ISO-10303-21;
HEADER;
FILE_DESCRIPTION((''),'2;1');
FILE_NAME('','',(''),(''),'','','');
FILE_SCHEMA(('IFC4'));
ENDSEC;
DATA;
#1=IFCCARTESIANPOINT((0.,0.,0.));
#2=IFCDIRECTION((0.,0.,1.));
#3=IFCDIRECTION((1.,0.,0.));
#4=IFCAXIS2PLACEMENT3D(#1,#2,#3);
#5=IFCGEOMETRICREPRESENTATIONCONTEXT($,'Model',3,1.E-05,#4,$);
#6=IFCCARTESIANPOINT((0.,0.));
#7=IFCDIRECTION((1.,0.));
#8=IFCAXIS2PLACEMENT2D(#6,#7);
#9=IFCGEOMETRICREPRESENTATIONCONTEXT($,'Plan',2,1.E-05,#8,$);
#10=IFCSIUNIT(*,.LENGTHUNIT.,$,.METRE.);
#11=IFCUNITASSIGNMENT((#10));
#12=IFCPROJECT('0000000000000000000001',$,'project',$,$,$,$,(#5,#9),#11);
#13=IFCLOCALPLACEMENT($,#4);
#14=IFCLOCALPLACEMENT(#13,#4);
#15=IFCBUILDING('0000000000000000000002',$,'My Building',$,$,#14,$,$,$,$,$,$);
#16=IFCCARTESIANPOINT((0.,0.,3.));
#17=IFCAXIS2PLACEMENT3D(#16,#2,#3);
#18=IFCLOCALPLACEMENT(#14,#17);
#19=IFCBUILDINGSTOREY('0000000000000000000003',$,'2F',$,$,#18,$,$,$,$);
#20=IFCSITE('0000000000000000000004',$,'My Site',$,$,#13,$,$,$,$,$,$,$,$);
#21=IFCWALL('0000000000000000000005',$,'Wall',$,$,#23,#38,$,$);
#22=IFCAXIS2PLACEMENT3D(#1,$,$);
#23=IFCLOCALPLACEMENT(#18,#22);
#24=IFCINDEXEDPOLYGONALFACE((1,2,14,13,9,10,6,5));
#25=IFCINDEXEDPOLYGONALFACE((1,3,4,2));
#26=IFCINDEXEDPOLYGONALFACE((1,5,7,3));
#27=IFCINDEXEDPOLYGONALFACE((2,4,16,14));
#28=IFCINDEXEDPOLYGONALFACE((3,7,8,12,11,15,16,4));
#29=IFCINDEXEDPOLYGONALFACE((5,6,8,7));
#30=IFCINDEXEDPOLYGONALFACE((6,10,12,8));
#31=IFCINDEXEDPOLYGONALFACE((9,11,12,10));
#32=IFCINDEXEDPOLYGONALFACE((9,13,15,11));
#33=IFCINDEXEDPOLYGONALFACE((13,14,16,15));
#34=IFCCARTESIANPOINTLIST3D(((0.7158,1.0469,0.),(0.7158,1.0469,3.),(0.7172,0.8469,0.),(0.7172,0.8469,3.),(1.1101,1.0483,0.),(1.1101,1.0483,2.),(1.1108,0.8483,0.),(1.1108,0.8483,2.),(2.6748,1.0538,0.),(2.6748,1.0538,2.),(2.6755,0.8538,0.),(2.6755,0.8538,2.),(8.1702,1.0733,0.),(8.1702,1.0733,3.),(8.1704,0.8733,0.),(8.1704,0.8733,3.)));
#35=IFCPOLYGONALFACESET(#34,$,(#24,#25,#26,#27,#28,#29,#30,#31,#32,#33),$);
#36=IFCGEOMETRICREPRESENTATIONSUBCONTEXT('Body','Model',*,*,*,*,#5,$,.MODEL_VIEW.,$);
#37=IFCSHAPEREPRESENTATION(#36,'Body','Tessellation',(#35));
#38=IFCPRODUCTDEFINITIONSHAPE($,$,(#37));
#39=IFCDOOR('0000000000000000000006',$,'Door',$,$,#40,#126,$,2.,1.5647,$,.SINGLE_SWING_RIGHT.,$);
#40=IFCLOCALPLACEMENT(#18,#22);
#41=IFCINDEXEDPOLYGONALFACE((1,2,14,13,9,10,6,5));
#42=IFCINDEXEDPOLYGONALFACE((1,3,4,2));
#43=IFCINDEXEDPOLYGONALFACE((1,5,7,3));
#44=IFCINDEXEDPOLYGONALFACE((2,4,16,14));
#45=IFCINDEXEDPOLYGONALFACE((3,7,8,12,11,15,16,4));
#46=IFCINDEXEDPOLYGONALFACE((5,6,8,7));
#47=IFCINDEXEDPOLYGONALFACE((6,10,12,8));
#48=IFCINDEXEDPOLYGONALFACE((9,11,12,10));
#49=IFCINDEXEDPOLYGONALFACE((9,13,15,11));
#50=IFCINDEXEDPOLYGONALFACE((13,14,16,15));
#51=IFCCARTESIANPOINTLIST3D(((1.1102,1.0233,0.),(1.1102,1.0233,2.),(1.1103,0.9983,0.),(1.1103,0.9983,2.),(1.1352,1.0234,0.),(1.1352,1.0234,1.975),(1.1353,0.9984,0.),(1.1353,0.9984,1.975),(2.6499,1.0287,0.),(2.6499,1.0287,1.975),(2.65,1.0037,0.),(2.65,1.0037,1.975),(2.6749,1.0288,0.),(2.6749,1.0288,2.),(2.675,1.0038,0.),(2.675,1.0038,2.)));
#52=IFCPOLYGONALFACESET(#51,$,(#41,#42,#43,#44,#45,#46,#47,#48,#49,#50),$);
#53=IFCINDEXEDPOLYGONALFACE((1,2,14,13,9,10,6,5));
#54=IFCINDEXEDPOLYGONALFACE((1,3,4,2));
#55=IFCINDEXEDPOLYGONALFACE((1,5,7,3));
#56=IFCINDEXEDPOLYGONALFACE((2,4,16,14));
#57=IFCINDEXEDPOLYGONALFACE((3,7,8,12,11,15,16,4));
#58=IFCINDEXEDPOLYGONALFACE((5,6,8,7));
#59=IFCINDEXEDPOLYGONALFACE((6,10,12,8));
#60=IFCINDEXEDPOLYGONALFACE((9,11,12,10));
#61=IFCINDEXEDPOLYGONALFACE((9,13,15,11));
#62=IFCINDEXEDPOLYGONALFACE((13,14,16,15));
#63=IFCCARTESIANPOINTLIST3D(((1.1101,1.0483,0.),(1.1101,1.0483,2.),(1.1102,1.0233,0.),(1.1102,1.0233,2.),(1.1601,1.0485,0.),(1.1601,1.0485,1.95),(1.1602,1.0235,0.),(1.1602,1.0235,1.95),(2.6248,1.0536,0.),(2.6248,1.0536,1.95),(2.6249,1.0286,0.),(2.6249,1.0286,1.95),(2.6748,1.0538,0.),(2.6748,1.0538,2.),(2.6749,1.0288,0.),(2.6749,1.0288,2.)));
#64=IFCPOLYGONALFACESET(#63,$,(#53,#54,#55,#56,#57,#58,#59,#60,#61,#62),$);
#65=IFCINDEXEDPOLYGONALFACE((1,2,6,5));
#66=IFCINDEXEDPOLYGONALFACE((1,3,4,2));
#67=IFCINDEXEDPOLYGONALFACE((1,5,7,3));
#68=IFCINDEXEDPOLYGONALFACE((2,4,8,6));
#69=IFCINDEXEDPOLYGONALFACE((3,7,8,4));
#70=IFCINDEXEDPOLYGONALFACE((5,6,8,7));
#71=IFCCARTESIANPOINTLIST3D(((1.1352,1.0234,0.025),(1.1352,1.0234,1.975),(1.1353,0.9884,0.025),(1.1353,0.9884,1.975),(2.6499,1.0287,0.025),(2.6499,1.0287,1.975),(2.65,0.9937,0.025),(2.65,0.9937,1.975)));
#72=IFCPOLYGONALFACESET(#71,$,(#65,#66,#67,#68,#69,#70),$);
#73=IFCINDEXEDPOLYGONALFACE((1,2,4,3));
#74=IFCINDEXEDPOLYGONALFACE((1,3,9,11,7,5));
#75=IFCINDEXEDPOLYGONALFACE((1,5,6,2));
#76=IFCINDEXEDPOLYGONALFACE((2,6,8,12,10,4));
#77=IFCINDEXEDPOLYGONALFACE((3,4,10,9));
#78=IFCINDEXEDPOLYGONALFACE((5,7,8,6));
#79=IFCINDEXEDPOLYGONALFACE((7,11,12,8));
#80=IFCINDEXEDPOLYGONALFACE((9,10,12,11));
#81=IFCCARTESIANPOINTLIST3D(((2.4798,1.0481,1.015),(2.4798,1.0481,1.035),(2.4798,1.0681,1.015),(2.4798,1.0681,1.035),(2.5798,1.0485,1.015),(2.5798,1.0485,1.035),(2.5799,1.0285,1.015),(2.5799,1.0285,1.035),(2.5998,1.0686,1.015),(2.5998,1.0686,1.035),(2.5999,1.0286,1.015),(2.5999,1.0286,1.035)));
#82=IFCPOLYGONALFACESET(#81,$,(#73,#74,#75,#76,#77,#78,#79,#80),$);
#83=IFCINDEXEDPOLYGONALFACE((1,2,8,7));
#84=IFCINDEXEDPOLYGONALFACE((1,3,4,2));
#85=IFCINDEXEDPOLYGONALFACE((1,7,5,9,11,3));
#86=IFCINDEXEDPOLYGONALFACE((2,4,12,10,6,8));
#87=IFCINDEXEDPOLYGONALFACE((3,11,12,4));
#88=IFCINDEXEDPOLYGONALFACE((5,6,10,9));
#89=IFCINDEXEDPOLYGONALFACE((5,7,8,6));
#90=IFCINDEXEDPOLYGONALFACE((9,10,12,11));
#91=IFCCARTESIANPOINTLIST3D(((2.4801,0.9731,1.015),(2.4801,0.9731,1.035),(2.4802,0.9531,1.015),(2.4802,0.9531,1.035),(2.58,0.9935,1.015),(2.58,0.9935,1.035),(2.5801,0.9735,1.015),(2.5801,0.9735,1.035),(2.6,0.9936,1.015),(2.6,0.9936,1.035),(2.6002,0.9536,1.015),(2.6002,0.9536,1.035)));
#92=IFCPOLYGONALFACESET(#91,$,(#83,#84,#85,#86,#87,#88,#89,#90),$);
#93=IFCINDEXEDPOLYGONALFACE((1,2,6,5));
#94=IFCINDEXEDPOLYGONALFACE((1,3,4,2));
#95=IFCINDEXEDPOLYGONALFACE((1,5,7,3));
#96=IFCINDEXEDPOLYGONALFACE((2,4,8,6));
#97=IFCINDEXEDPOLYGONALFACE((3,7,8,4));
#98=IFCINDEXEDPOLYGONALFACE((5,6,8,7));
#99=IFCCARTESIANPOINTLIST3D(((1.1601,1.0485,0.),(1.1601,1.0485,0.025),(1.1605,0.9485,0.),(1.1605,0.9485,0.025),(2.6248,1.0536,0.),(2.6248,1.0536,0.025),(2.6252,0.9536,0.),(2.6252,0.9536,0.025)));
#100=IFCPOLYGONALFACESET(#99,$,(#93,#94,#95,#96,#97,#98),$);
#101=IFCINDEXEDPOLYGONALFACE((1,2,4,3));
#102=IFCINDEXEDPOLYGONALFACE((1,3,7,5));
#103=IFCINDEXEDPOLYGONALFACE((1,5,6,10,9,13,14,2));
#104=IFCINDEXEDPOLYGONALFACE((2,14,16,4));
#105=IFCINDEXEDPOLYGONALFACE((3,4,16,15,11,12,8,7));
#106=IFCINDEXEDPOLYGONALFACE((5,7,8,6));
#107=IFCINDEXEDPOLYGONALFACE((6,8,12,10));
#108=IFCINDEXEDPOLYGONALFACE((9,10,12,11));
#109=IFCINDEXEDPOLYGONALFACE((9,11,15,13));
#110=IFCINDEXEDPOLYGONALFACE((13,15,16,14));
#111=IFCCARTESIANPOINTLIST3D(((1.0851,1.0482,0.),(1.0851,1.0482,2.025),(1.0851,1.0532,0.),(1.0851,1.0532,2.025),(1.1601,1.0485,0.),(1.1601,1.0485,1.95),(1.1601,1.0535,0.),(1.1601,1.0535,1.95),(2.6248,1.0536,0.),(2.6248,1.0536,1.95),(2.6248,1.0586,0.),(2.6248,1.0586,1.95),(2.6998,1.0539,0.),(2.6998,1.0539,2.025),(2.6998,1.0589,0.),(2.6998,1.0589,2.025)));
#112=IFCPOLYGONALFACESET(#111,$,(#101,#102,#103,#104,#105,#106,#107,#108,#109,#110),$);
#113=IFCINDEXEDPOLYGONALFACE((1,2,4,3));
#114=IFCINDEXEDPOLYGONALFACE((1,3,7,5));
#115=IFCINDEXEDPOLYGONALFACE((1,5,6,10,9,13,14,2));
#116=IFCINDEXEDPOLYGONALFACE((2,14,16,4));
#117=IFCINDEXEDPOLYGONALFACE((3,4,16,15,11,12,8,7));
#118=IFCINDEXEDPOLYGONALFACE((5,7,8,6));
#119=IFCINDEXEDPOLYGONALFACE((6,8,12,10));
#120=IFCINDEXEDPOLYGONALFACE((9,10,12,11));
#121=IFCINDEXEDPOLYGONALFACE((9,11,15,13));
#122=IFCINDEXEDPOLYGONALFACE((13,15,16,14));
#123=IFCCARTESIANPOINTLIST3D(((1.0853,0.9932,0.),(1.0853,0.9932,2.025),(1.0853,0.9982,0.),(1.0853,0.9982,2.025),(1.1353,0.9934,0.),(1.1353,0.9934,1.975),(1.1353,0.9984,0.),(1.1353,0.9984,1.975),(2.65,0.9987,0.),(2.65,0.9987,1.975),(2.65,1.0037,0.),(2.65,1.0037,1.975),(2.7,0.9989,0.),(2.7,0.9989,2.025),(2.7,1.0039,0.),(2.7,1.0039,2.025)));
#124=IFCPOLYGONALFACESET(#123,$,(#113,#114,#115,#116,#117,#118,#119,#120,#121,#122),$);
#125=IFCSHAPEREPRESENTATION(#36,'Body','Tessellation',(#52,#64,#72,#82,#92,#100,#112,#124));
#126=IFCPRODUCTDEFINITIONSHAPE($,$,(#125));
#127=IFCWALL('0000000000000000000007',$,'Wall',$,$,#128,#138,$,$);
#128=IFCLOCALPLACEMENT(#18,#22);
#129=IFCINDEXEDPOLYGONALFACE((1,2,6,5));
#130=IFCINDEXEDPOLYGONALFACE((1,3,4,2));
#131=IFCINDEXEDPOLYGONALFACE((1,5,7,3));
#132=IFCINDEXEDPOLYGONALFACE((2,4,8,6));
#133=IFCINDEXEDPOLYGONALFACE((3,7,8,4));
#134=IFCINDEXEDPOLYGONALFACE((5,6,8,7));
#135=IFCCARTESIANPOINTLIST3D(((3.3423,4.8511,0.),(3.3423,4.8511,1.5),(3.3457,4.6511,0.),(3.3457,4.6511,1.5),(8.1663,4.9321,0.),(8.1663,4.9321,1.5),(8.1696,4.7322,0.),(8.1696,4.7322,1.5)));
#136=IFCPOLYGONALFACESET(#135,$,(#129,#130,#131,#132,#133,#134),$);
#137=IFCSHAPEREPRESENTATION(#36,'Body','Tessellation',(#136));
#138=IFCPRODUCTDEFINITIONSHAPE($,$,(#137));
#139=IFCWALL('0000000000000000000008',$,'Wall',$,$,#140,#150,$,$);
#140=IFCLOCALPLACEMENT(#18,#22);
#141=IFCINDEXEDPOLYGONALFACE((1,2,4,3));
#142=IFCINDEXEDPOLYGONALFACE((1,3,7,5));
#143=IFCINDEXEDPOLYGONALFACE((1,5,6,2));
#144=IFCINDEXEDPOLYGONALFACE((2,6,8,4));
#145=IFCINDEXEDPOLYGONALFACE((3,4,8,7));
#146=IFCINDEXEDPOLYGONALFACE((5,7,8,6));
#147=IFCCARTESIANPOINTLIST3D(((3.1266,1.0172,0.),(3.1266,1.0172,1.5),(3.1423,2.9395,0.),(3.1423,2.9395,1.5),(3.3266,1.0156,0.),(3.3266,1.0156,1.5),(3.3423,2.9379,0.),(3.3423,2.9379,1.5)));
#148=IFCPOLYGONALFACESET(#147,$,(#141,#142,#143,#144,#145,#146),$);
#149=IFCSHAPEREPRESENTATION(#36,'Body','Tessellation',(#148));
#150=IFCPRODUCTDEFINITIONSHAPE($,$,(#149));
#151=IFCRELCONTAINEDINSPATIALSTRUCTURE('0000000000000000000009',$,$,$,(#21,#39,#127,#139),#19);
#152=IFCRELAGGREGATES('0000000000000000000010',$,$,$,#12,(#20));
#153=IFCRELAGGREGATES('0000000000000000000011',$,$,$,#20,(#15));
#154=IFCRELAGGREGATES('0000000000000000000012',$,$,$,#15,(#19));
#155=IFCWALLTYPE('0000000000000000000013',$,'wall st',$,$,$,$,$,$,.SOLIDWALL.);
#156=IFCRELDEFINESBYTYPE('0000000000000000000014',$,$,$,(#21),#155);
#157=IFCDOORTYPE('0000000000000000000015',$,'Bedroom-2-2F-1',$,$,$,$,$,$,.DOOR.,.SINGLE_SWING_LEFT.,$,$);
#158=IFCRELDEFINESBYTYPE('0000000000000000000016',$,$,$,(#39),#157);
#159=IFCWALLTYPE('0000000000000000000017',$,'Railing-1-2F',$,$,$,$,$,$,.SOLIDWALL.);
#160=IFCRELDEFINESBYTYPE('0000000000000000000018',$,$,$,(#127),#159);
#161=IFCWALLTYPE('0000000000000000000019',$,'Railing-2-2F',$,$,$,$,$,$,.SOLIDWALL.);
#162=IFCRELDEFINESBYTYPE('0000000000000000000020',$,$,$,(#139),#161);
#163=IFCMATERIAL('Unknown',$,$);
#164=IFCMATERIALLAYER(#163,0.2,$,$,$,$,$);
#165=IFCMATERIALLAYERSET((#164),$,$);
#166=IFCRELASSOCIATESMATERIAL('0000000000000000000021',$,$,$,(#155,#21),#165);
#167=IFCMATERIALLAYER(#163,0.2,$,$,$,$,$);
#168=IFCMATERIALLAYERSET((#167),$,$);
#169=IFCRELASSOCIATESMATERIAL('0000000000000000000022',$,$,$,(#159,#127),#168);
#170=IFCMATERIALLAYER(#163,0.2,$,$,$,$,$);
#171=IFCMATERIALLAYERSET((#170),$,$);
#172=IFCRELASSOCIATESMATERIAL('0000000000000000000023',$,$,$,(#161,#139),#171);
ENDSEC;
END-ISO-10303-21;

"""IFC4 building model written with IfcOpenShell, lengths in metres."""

from ifc_helpers import new_model, entity, si_unit, frame, origin_with_axes, origin_2d_with_axis, place, context, subcontext, project, spatial, line, indexed_curve, outline, extrude, shape, source, transform, mapped, material, layer, layer_set, layer_usage, type_object, type_shapes, element, fill, save


model = new_model("IFC4")

# Units and contexts
model_context = context("Model", 3, precision=1e-05, world=origin_with_axes())
plan_context = context("Plan", 2, precision=1e-05, world=origin_2d_with_axis())
body_context_1 = subcontext(model_context, "Body", "Model", "MODEL_VIEW")
body_context_2 = subcontext(plan_context, "Body", "Plan", "PLAN_VIEW")
ifc_project = project(units=[si_unit("LENGTHUNIT", "METRE")], contexts=[model_context, plan_context])

# Site, building, storey
site_placement = place(None, origin_with_axes())
site = spatial("IfcSite", under=ifc_project, at=site_placement, Name="My Site")
building_placement = place(site_placement, origin_with_axes())
building = spatial("IfcBuilding", under=site, at=building_placement, Name="My Building")
storey_placement = place(building_placement, frame((0.0, 0.0, 3.0), z_axis=(0.0, 0.0, 1.0), x_axis=(1.0, 0.0, 0.0)))
storey = spatial("IfcBuildingStorey", under=building, at=storey_placement, Name="2F")

# Shared definitions
ifc_material = material(Name="Unknown")

# Shared definitions
ifc_layer_1 = layer(ifc_material, 0.2)
ifc_layer_set_1 = layer_set([ifc_layer_1])
wall_type_1 = type_object("IfcWallType", Name="wall st", PredefinedType="SOLIDWALL", material=ifc_layer_set_1)

# Wall, opening, door
ifc_layer_usage_1 = layer_usage(ifc_layer_set_1, "AXIS2", "POSITIVE", 0.0)
wall_1_placement = place(storey_placement, frame((0.5172, 0.8462, 0.0), z_axis=(0.0, 0.0, 1.0), x_axis=(0.999994, 0.003537, 0.0)))
wall_1 = element("IfcWall", 1, at=wall_1_placement, inside=storey, type_object=wall_type_1, material=ifc_layer_usage_1, Name="Wall", context=body_context_1, shape_type="SweptSolid", body=[
    extrude(outline(indexed_curve([(0.2, 0.0), (0.1993, 0.2), (7.6537, 0.2), (7.6532, 0.0)], segments=[line(1, 2, 3, 4, 1)])), origin_with_axes(), (0.0, 0.0, 1.0), 3.0),
])
shared_shape_1 = source(origin_with_axes(), body_context_1, "Body", "SweptSolid", [
    extrude(outline(indexed_curve([(0.0, 0.0), (1.5647, 0.0), (1.5647, 2.0), (0.0, 2.0)], segments=[line(1, 2, 3, 4, 1)])), frame((0.0, -0.6, 0.0), z_axis=(0.0, -1.0, 0.0), x_axis=(1.0, 0.0, 0.0)), (0.0, 0.0, -1.0), 1.2),
])
opening_1_placement = place(wall_1_placement, frame((2.1583, 0.2, 0.0), z_axis=(0.0, 0.0, 1.0), x_axis=(-1.0, 0.0, 0.0)))
opening_1 = element("IfcOpeningElement", 2, at=opening_1_placement, cuts=wall_1, PredefinedType="OPENING", context=body_context_1, shape_type="MappedRepresentation", body=[
    mapped(shared_shape_1, transform((0.0, 0.0, 0.0), x_axis=(1.0, 0.0, 0.0), y_axis=(0.0, 1.0, 0.0), z_axis=(0.0, 0.0, 1.0), scale=1.0)),
])
door_type_1 = type_object("IfcDoorType", Name="Bedroom-2-2F-1", OperationType="SINGLE_SWING_LEFT", PredefinedType="DOOR")
shared_shape_2 = source(origin_with_axes(), body_context_1, "Body", "SweptSolid", [
    extrude(outline(indexed_curve([(0.0, 0.0), (0.0, 2.0), (1.5647, 2.0), (1.5647, 0.0), (1.5397, 0.0), (1.5397, 1.975), (0.025, 1.975), (0.025, 0.0)], segments=[line(1, 2, 3, 4, 5, 6, 7, 8, 1)])), frame((0.0, 0.025, 0.0), z_axis=(0.0, -1.0, 0.0), x_axis=(1.0, 0.0, 0.0)), (0.0, 0.0, -1.0), 0.025),
    extrude(outline(indexed_curve([(0.0, 0.0), (0.0, 2.0), (1.5647, 2.0), (1.5647, 0.0), (1.5147, 0.0), (1.5147, 1.95), (0.05, 1.95), (0.05, 0.0)], segments=[line(1, 2, 3, 4, 5, 6, 7, 8, 1)])), frame((0.0, 0.0, 0.0), z_axis=(0.0, -1.0, 0.0), x_axis=(1.0, 0.0, 0.0)), (0.0, 0.0, -1.0), 0.025),
    extrude(outline(indexed_curve([(0.0, 0.0), (1.5147, 0.0), (1.5147, 0.035), (0.0, 0.035)], segments=[line(1, 2, 3, 4, 1)])), frame((0.025, 0.025, 0.025), z_axis=(0.0, 0.0, 1.0), x_axis=(1.0, 0.0, 0.0)), (0.0, 0.0, 1.0), 1.95),
    extrude(outline(indexed_curve([(0.0, 0.0), (0.0, -0.04), (0.12, -0.04), (0.12, -0.02), (0.02, -0.02), (0.02, 0.0)], segments=[line(1, 2, 3, 4, 5, 6, 1)])), frame((0.075, 0.025, 1.015), z_axis=(0.0, 0.0, 1.0), x_axis=(1.0, 0.0, 0.0)), (0.0, 0.0, 1.0), 0.02),
    extrude(outline(indexed_curve([(0.0, 0.0), (0.0, 0.04), (0.12, 0.04), (0.12, 0.02), (0.02, 0.02), (0.02, 0.0)], segments=[line(1, 2, 3, 4, 5, 6, 1)])), frame((0.075, 0.06, 1.015), z_axis=(0.0, 0.0, 1.0), x_axis=(1.0, 0.0, 0.0)), (0.0, 0.0, 1.0), 0.02),
    extrude(outline(indexed_curve([(0.0, 0.0), (1.4647, 0.0), (1.4647, 0.1), (0.0, 0.1)], segments=[line(1, 2, 3, 4, 1)])), frame((0.05, 0.0, 0.0), z_axis=(0.0, 0.0, 1.0), x_axis=(1.0, 0.0, 0.0)), (0.0, 0.0, 1.0), 0.025),
    extrude(outline(indexed_curve([(0.0, 0.0), (0.0, 2.025), (1.6147, 2.025), (1.6147, 0.0), (1.5397, 0.0), (1.5397, 1.95), (0.075, 1.95), (0.075, 0.0)], segments=[line(1, 2, 3, 4, 5, 6, 7, 8, 1)])), frame((-0.025, -0.005, 0.0), z_axis=(0.0, -1.0, 0.0), x_axis=(1.0, 0.0, 0.0)), (0.0, 0.0, -1.0), 0.005),
    extrude(outline(indexed_curve([(0.0, 0.0), (0.0, 2.025), (1.6147, 2.025), (1.6147, 0.0), (1.5647, 0.0), (1.5647, 1.975), (0.05, 1.975), (0.05, 0.0)], segments=[line(1, 2, 3, 4, 5, 6, 7, 8, 1)])), frame((-0.025, 0.05, 0.0), z_axis=(0.0, -1.0, 0.0), x_axis=(1.0, 0.0, 0.0)), (0.0, 0.0, -1.0), 0.005),
])
shared_shape_3 = source(origin_with_axes(), body_context_2, "Body", "Curve2D", [
    entity("IfcIndexedPolyCurve", entity("IfcCartesianPointList2D", [[0.0, 0.0], [0.0, 0.05], [0.025, 0.05], [0.025, 0.025], [0.05, 0.025], [0.05, 0.0]]), [entity("IfcLineIndex", [1, 2, 3, 4, 5, 6, 1])]),
    entity("IfcIndexedPolyCurve", entity("IfcCartesianPointList2D", [[1.5647, 0.0], [1.5647, 0.05], [1.5397, 0.05], [1.5397, 0.025], [1.5147, 0.025], [1.5147, 0.0]]), [entity("IfcLineIndex", [1, 2, 3, 4, 5, 6, 1])]),
    entity("IfcTrimmedCurve", entity("IfcEllipse", entity("IfcAxis2Placement2D", entity("IfcCartesianPoint", [1.5047, 0.05]), entity("IfcDirection", [1.0, 0.0])), 1.4797, 1.5147), [entity("IfcCartesianPoint", [1.5047, 1.5647])], [entity("IfcCartesianPoint", [0.025, 0.05])], True, "CARTESIAN"),
    entity("IfcIndexedPolyCurve", entity("IfcCartesianPointList2D", [[1.5397, 0.05], [1.5047, 0.05], [1.5047, 1.5647], [1.5397, 1.5647]]), [entity("IfcLineIndex", [1, 2, 3, 4, 1])]),
])
type_shapes(door_type_1, [shared_shape_2, shared_shape_3])
door_1_placement = place(opening_1_placement, origin_with_axes())
door_1 = element("IfcDoor", 3, at=door_1_placement, inside=storey, type_object=door_type_1, Name="Door", OperationType="SINGLE_SWING_RIGHT", OverallHeight=2.0, OverallWidth=1.5647, shapes=[
    shape(body_context_1, "Body", "MappedRepresentation", [mapped(shared_shape_2, transform((0.0, 0.0, 0.0), x_axis=(1.0, 0.0, 0.0), y_axis=(0.0, 1.0, 0.0), z_axis=(0.0, 0.0, 1.0), scale=1.0))]),
    shape(body_context_2, "Body", "MappedRepresentation", [mapped(shared_shape_3, transform((0.0, 0.0, 0.0), x_axis=(1.0, 0.0, 0.0), y_axis=(0.0, 1.0, 0.0), z_axis=(0.0, 0.0, 1.0), scale=1.0))]),
])
fill(opening_1, door_1)

# Walls
ifc_layer_2 = layer(ifc_material, 0.2)
ifc_layer_set_2 = layer_set([ifc_layer_2])
ifc_layer_usage_2 = layer_usage(ifc_layer_set_2, "AXIS2", "POSITIVE", 0.0)
wall_type_2 = type_object("IfcWallType", Name="Railing-1-2F", PredefinedType="SOLIDWALL", material=ifc_layer_set_2)
wall_2_placement = place(storey_placement, frame((8.1663, 4.9321, 0.0), z_axis=(0.0, 0.0, 1.0), x_axis=(-0.999859, -0.016799, 0.0)))
element("IfcWall", 4, at=wall_2_placement, inside=storey, type_object=wall_type_2, material=ifc_layer_usage_2, Name="Wall", context=body_context_1, shape_type="SweptSolid", body=[
    extrude(outline(indexed_curve([(0.0, 0.0), (0.0, 0.2), (4.8247, 0.2), (4.8247, 0.0)], segments=[line(1, 2, 3, 4, 1)])), origin_with_axes(), (0.0, 0.0, 1.0), 1.5),
])
ifc_layer_3 = layer(ifc_material, 0.2)
ifc_layer_set_3 = layer_set([ifc_layer_3])
ifc_layer_usage_3 = layer_usage(ifc_layer_set_3, "AXIS2", "POSITIVE", 0.0)
wall_type_3 = type_object("IfcWallType", Name="Railing-2-2F", PredefinedType="SOLIDWALL", material=ifc_layer_set_3)
wall_3_placement = place(storey_placement, frame((3.1423, 2.9395, 0.0), z_axis=(0.0, 0.0, 1.0), x_axis=(-0.008162, -0.999967, 0.0)))
element("IfcWall", 5, at=wall_3_placement, inside=storey, type_object=wall_type_3, material=ifc_layer_usage_3, Name="Wall", context=body_context_1, shape_type="SweptSolid", body=[
    extrude(outline(indexed_curve([(0.0, 0.0), (0.0, 0.2), (1.9223, 0.2), (1.9223, 0.0)], segments=[line(1, 2, 3, 4, 1)])), origin_with_axes(), (0.0, 0.0, 1.0), 1.5),
])

save(model, "model.ifc")
